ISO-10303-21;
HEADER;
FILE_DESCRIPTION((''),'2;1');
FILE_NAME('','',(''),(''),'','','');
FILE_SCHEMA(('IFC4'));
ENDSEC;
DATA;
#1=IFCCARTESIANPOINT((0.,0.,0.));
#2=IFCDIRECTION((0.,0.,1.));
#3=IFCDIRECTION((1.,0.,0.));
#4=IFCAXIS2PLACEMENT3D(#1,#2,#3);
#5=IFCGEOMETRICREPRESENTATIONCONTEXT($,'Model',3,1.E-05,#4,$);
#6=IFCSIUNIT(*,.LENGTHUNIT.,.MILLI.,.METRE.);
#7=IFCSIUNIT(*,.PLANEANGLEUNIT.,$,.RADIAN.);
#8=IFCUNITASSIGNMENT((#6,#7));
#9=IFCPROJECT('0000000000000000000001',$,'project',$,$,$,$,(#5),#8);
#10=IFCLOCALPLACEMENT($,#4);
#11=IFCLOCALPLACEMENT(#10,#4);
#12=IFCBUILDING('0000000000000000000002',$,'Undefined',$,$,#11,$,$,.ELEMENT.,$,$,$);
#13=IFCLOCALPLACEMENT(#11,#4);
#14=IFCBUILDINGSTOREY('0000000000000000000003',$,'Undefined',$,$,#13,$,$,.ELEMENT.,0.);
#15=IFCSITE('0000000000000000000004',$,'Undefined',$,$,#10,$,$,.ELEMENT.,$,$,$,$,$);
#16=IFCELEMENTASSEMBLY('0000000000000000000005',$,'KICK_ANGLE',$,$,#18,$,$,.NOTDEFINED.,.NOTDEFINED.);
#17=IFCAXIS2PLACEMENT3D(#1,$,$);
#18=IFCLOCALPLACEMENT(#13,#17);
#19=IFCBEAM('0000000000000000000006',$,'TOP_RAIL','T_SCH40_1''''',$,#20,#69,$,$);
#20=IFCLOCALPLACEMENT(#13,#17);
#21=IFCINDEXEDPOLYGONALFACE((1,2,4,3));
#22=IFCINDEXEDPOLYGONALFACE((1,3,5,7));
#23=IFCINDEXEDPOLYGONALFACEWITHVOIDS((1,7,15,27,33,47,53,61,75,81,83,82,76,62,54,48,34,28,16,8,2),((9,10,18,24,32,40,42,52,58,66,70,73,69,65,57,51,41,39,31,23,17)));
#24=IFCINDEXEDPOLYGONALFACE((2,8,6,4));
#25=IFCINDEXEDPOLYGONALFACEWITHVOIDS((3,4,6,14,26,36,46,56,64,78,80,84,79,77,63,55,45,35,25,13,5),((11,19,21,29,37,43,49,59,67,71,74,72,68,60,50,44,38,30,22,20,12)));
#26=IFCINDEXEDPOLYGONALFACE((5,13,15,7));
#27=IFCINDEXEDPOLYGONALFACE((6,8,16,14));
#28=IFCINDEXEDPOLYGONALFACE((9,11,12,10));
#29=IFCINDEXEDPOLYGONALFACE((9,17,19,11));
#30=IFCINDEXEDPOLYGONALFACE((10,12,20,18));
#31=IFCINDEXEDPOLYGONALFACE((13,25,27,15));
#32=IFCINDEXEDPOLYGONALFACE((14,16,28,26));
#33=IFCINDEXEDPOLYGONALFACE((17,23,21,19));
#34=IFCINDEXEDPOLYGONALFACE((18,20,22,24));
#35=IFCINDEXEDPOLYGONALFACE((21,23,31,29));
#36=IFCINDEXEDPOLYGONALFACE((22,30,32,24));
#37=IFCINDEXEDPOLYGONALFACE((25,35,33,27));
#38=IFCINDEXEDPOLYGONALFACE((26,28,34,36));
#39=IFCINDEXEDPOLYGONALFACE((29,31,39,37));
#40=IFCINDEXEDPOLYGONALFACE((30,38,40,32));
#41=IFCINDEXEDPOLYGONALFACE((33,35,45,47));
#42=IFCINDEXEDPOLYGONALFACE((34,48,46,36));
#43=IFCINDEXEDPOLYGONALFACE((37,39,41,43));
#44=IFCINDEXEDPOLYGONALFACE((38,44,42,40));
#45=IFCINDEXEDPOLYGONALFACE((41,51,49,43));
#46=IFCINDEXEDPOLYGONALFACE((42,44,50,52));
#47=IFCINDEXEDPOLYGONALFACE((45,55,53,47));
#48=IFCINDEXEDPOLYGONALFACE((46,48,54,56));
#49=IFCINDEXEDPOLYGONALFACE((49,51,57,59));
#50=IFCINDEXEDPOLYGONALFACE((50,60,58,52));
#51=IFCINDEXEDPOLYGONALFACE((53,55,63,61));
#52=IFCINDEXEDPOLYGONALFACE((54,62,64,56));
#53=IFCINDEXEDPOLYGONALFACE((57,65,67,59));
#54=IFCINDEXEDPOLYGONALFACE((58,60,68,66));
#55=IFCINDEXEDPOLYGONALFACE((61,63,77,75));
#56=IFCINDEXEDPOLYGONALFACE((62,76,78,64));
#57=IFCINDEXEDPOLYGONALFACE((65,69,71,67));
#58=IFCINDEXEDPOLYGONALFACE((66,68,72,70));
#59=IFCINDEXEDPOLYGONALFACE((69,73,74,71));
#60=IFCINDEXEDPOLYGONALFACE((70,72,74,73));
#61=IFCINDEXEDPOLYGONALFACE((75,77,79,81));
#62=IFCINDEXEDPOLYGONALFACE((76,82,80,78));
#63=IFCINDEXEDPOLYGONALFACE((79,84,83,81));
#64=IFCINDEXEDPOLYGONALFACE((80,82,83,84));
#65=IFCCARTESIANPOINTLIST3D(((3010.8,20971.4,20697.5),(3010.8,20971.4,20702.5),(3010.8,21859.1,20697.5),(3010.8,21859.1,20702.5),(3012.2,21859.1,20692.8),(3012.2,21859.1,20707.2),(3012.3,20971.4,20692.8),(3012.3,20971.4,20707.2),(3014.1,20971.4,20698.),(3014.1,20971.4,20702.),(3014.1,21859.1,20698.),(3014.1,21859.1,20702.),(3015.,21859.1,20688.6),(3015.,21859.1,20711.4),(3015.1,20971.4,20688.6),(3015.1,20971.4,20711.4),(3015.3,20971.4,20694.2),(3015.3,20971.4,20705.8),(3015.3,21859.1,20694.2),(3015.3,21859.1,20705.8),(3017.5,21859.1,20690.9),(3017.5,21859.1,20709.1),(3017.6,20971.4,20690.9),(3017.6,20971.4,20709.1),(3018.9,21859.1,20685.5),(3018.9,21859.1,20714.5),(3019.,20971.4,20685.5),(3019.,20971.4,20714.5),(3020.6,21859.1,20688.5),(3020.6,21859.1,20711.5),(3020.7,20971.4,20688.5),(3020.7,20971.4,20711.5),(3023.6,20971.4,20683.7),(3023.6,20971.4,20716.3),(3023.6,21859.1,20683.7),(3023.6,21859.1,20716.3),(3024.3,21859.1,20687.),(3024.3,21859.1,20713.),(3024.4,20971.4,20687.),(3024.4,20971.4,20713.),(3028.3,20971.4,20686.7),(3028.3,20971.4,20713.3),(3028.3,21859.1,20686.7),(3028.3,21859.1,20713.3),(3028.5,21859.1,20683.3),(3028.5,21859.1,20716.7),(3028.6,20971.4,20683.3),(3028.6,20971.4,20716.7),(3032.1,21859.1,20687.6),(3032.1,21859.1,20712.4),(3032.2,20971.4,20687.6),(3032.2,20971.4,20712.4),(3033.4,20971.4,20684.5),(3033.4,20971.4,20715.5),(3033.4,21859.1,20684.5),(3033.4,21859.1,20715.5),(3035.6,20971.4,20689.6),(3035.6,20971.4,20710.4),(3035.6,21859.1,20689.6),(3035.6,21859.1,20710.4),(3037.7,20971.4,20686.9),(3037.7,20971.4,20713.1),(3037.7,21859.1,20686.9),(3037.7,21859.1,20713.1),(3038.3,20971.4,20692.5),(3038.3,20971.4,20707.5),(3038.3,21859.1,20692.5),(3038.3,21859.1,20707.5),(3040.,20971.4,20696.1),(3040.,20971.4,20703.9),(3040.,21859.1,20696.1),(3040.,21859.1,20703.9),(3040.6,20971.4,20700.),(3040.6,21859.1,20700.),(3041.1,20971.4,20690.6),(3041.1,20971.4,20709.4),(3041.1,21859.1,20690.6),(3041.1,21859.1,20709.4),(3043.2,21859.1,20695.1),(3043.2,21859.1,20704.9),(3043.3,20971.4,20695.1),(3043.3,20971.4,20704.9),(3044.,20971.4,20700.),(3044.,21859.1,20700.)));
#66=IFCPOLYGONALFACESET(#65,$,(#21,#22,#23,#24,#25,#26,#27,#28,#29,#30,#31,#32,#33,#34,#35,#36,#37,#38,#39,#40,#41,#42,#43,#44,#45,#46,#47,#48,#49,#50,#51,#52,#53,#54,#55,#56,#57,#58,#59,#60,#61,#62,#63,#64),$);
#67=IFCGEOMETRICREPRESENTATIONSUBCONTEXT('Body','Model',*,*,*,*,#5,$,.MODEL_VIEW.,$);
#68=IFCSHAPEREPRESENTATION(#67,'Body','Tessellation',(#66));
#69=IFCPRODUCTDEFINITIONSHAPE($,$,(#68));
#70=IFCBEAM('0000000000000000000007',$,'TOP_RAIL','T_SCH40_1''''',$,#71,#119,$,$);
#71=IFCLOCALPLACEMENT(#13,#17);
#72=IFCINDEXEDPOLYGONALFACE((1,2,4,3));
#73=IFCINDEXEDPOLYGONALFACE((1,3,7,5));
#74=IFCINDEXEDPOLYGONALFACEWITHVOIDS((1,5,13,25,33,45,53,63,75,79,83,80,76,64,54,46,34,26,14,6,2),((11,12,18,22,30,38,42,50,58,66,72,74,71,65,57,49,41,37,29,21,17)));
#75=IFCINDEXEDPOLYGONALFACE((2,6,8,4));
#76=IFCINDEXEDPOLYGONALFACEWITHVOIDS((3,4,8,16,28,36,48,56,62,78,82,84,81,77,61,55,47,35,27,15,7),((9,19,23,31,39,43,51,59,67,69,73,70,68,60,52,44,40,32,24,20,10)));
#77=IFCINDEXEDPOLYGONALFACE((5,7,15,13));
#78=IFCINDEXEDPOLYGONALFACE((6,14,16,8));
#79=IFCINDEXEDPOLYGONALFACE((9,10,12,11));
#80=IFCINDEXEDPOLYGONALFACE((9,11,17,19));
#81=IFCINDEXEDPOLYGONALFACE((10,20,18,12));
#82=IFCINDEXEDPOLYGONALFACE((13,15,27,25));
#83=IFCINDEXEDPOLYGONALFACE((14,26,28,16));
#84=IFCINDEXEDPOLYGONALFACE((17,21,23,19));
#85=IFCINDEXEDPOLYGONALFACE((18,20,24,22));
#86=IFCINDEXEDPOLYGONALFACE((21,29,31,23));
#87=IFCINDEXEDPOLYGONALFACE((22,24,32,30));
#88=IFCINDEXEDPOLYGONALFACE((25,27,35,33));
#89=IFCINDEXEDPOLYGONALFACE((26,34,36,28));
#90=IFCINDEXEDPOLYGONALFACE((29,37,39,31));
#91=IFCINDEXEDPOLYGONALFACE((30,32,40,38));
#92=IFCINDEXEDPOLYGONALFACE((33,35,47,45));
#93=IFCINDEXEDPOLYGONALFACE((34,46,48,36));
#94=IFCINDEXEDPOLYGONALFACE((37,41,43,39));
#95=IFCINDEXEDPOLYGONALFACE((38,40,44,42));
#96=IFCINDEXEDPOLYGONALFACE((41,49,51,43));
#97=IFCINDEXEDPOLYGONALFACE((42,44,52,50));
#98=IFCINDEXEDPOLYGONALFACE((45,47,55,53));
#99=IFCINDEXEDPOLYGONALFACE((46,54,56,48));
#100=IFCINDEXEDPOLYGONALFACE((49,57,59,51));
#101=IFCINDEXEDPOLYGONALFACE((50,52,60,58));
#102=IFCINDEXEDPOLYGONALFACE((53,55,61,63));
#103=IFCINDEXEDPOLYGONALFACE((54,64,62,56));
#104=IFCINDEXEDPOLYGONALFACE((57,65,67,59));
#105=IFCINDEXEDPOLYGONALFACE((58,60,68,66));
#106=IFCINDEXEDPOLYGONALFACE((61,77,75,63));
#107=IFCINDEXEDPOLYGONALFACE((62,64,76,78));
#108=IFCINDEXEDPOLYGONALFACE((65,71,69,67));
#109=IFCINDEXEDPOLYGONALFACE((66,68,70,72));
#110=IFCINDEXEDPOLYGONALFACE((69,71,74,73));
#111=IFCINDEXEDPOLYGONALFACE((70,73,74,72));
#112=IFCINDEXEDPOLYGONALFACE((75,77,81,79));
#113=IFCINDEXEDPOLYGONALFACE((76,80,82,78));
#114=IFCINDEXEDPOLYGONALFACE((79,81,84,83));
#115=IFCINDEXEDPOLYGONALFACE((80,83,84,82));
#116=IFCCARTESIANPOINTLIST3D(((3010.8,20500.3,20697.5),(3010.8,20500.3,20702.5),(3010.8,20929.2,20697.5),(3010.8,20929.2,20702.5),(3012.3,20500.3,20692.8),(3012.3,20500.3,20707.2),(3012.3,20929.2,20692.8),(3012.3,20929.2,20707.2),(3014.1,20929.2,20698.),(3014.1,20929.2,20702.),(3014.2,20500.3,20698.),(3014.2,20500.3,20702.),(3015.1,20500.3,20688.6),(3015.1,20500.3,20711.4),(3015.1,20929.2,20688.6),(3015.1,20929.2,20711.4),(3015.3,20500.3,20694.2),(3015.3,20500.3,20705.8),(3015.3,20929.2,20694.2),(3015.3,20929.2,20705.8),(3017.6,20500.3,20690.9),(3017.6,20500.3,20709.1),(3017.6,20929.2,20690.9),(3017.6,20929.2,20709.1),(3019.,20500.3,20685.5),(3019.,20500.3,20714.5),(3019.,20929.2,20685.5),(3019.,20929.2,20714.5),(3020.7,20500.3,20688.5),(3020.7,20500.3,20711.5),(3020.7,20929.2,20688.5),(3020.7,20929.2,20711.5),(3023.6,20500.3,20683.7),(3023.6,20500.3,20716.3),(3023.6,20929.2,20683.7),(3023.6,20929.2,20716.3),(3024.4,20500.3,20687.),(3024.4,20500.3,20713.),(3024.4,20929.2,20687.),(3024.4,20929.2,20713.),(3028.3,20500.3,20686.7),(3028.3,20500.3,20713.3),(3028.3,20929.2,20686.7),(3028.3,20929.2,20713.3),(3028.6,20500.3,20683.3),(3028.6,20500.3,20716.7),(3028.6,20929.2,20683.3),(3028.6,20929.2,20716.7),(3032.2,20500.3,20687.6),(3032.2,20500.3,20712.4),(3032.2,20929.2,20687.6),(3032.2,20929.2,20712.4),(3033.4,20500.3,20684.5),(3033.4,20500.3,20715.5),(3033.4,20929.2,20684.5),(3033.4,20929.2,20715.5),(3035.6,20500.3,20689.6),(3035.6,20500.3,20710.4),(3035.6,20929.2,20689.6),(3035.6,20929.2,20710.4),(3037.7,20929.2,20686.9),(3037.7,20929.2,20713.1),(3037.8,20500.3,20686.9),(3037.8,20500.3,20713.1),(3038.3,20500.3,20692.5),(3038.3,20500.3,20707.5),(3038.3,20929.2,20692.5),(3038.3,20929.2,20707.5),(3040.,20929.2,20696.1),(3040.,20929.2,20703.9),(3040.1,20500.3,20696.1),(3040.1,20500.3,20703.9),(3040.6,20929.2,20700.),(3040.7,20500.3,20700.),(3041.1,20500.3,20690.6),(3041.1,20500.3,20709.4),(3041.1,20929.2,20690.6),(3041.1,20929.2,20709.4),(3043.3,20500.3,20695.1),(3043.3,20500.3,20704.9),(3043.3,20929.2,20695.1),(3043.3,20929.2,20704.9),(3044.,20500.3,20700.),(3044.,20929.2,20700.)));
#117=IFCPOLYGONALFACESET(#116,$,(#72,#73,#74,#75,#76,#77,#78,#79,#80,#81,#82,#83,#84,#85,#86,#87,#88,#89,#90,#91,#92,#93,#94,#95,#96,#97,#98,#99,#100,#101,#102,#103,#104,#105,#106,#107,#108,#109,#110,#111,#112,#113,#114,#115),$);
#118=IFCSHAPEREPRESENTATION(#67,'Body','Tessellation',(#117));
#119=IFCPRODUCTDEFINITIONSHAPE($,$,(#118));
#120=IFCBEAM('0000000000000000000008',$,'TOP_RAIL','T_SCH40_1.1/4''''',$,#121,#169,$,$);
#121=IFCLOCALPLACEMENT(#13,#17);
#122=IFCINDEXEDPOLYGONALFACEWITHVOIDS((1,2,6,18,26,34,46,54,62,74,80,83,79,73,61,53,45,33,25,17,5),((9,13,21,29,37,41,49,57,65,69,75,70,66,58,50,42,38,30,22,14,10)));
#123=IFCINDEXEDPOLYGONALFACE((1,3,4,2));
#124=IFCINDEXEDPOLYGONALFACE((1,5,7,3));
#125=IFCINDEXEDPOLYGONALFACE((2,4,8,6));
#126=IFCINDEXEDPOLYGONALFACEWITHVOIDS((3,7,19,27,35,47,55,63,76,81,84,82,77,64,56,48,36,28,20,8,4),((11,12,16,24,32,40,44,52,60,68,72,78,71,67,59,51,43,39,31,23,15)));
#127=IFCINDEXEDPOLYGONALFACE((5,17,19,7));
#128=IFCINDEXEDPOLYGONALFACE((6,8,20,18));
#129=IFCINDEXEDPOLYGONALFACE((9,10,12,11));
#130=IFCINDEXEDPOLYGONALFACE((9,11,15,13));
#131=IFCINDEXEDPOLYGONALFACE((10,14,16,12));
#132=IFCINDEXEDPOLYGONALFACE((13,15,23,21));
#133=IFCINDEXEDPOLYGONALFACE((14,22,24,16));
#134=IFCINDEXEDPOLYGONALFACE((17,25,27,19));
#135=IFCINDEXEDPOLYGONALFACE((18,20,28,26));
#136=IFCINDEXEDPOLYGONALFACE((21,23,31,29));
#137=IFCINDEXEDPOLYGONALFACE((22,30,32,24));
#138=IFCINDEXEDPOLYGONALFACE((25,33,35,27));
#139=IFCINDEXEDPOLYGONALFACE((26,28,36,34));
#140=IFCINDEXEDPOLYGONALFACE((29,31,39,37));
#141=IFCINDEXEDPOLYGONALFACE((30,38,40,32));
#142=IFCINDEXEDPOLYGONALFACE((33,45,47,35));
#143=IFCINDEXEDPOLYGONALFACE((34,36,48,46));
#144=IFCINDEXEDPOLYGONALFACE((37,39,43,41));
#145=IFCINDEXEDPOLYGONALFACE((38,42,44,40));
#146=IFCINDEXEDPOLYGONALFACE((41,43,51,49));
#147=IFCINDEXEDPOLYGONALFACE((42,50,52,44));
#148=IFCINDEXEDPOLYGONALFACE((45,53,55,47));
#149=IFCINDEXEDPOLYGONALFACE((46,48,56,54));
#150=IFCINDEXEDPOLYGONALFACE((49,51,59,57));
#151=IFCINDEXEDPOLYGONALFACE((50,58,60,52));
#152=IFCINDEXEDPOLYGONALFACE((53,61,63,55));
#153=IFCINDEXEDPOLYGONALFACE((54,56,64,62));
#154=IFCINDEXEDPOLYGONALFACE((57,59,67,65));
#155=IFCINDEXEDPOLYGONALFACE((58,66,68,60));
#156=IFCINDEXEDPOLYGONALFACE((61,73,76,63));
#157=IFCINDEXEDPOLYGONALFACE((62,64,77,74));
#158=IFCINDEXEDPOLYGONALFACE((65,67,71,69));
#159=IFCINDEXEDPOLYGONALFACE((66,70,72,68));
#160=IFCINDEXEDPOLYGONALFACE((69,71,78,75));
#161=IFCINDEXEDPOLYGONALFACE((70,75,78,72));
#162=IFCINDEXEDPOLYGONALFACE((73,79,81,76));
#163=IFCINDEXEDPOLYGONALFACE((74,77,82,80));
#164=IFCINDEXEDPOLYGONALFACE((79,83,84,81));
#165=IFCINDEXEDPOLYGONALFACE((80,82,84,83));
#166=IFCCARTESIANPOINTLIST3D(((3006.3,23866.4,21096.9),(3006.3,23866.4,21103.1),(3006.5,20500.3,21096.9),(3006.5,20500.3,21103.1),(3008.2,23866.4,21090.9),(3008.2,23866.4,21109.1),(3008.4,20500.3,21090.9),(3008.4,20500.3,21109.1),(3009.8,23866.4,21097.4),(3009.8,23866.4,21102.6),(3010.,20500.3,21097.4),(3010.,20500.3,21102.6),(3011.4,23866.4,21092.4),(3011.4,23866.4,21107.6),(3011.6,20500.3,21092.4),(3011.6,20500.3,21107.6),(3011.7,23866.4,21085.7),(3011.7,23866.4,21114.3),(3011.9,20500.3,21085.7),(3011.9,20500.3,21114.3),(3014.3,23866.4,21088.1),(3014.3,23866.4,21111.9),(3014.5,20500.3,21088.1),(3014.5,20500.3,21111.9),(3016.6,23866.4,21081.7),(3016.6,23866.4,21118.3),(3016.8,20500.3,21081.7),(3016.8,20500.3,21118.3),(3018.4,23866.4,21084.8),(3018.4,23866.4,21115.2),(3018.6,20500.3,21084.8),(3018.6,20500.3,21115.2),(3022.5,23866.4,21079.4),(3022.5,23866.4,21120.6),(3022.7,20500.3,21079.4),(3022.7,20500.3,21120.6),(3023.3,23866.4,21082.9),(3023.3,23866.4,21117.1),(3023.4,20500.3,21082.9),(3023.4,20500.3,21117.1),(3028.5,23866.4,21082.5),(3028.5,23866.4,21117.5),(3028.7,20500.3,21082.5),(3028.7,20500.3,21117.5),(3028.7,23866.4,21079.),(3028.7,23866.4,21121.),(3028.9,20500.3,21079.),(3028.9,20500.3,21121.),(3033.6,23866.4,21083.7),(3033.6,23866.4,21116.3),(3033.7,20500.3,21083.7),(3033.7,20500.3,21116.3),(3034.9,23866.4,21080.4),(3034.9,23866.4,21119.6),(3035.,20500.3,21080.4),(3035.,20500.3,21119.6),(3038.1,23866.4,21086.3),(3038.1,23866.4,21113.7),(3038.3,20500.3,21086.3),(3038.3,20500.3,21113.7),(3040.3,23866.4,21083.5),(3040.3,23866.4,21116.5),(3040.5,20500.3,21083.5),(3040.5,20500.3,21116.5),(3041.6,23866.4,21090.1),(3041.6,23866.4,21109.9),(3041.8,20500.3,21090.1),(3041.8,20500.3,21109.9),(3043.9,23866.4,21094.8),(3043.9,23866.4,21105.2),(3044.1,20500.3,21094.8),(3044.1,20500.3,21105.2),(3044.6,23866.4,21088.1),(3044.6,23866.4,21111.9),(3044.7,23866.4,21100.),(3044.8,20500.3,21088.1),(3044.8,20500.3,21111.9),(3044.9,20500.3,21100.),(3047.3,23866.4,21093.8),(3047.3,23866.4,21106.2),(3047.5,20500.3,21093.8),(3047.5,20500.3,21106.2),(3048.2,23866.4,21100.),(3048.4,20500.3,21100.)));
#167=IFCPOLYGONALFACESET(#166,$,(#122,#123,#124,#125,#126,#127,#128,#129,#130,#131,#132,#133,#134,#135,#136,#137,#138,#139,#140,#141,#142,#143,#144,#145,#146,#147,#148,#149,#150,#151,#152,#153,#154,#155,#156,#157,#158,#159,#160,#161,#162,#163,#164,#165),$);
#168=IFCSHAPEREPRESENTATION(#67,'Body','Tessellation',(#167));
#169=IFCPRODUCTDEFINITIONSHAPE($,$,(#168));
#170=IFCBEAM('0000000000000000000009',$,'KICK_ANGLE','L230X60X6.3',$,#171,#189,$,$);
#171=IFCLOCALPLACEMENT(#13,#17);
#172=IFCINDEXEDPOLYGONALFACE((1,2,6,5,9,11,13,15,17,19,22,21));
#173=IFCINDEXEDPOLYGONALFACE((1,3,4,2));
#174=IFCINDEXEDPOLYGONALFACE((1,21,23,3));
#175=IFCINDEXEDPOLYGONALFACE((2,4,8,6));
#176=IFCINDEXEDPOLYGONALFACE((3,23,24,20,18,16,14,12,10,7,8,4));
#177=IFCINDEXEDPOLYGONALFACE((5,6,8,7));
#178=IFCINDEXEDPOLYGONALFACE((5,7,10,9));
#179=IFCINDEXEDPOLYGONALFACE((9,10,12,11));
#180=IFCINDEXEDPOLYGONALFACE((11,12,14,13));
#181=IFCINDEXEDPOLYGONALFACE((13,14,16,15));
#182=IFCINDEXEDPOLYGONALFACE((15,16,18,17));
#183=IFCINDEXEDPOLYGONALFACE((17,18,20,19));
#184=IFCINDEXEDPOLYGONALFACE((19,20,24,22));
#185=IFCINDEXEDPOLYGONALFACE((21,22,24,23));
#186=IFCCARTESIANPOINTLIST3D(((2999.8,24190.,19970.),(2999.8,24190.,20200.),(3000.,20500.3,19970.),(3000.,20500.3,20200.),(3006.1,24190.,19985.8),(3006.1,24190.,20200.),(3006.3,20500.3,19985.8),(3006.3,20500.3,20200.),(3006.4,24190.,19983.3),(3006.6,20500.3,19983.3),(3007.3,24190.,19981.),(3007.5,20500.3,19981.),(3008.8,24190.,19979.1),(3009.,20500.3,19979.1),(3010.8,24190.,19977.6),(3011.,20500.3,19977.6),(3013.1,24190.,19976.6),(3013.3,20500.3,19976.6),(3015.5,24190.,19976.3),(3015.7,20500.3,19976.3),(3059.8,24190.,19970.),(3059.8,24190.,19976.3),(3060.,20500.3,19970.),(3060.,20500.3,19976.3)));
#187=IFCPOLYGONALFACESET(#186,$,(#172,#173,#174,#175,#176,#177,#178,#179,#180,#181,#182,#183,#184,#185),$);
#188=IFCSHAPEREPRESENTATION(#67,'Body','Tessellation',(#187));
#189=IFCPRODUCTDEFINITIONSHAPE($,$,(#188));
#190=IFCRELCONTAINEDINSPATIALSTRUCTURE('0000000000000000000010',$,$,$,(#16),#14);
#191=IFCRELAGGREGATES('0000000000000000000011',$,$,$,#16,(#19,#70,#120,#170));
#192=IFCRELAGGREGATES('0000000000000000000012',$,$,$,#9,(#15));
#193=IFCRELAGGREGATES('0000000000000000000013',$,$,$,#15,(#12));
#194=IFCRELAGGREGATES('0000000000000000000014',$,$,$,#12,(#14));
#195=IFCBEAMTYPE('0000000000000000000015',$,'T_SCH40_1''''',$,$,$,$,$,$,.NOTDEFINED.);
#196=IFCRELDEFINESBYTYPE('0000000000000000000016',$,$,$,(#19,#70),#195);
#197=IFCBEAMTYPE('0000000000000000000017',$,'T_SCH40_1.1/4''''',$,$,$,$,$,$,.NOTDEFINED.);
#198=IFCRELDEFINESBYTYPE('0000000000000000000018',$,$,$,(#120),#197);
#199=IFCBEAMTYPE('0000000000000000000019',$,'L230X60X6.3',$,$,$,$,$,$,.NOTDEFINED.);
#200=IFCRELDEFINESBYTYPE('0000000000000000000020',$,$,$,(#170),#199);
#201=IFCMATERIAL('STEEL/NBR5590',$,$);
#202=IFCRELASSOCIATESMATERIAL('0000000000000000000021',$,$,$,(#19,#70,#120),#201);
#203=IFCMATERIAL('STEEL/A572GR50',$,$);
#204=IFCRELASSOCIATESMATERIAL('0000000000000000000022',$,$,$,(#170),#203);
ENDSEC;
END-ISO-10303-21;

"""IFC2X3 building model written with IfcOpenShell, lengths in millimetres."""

from ifc_helpers import new_model, si_unit, frame, origin_with_axes, origin_2d_with_axis, place, context, subcontext, project, spatial, hollow_circle, l_section, extrude, clip, halfspace, material, type_object, element, aggregate, save


model = new_model("IFC2X3")

# Units and contexts
model_context = context("Model", 3, precision=1e-05, world=origin_with_axes())
body_context = subcontext(model_context, "Body", "Model", "MODEL_VIEW")
ifc_project = project(units=[si_unit("LENGTHUNIT", "METRE", prefix="MILLI"), si_unit("PLANEANGLEUNIT", "RADIAN")], contexts=[model_context])

# Site, building, storey
site_placement = place(None, origin_with_axes())
site = spatial("IfcSite", under=ifc_project, at=site_placement, Name="Undefined", CompositionType="ELEMENT")
building_placement = place(site_placement, origin_with_axes())
building = spatial("IfcBuilding", under=site, at=building_placement, Name="Undefined", CompositionType="ELEMENT")
storey_placement = place(building_placement, origin_with_axes())
storey = spatial("IfcBuildingStorey", under=building, at=storey_placement, Name="Undefined", CompositionType="ELEMENT", Elevation=0.0)

# Element assembly
ifc_material_1 = material(Name="STEEL/A572GR50")
assembly_1_placement = place(storey_placement, origin_with_axes())
assembly_1 = element("IfcElementAssembly", 1, at=assembly_1_placement, inside=storey, Name="KICK_ANGLE", AssemblyPlace="NOTDEFINED", PredefinedType="NOTDEFINED")
ifc_material_2 = material(Name="STEEL/NBR5590")

# Beams
beam_type_1 = type_object("IfcBeamType", Name="T_SCH40_1''", PredefinedType="NOTDEFINED")
beam_1_placement = place(assembly_1_placement, frame((3027.3, 20971.4, 20700.0), z_axis=(0.0, 0.0, 1.0), x_axis=(-0.000052, 1.0, 0.0)))
beam_1 = element("IfcBeam", 2, at=beam_1_placement, type_object=beam_type_1, material=ifc_material_2, Name="TOP_RAIL", Description="T_SCH40_1''", context=body_context, shape_type="SweptSolid", body=[
    extrude(hollow_circle(Radius=16.7, WallThickness=3.4, at=origin_2d_with_axis()), frame((887.7, 0.0, 0.0), z_axis=(-1.0, 0.0, 0.0), x_axis=(0.0, -1.0, 0.0)), (0.0, 0.0, 1.0), 887.7),
])
beam_2_placement = place(assembly_1_placement, frame((3027.3, 20500.3, 20700.0), z_axis=(0.0, 0.0, 1.0), x_axis=(-0.000052, 1.0, 0.0)))
beam_2 = element("IfcBeam", 3, at=beam_2_placement, type_object=beam_type_1, material=ifc_material_2, Name="TOP_RAIL", Description="T_SCH40_1''", context=body_context, shape_type="SweptSolid", body=[
    extrude(hollow_circle(Radius=16.7, WallThickness=3.4, at=origin_2d_with_axis()), frame((428.9, 0.0, 0.0), z_axis=(-1.0, 0.0, 0.0), x_axis=(0.0, -1.0, 0.0)), (0.0, 0.0, 1.0), 428.9),
])

# Beams
beam_type_2 = type_object("IfcBeamType", Name="T_SCH40_1.1/4''", PredefinedType="NOTDEFINED")
beam_3_placement = place(assembly_1_placement, frame((3027.3, 20500.3, 21100.0), z_axis=(0.0, 0.0, 1.0), x_axis=(-0.000052, 1.0, 0.0)))
beam_3 = element("IfcBeam", 4, at=beam_3_placement, type_object=beam_type_2, material=ifc_material_2, Name="TOP_RAIL", Description="T_SCH40_1.1/4''", context=body_context, shape_type="Clipping", body=[
    clip(extrude(hollow_circle(Radius=21.1, WallThickness=3.6, at=origin_2d_with_axis()), frame((3689.7, 0.0, 0.0), z_axis=(-1.0, 0.0, 0.0), x_axis=(0.0, -1.0, 0.0)), (0.0, 0.0, 1.0), 3689.7), halfspace(frame((3366.1, 0.0, 0.0), z_axis=(1.0, 0.0, 0.0), x_axis=(0.0, -1.0, 0.0)), False)),
])
beam_type_3 = type_object("IfcBeamType", Name="L230X60X6.3", PredefinedType="NOTDEFINED")
beam_4_placement = place(assembly_1_placement, frame((3030.0, 20500.3, 20085.0), z_axis=(0.0, 0.0, 1.0), x_axis=(-0.000052, 1.0, 0.0)))
beam_4 = element("IfcBeam", 5, at=beam_4_placement, type_object=beam_type_3, material=ifc_material_1, Name="KICK_ANGLE", Description="L230X60X6.3", context=body_context, shape_type="SweptSolid", body=[
    extrude(l_section(Depth=230.0, Width=60.0, Thickness=6.3, FilletRadius=9.4, at=origin_2d_with_axis()), frame((3689.7, 0.0, 0.0), z_axis=(-1.0, 0.0, 0.0), x_axis=(0.0, -1.0, 0.0)), (0.0, 0.0, 1.0), 3689.7),
])

aggregate(assembly_1, [beam_1, beam_2, beam_3, beam_4])

save(model, "model.ifc")
